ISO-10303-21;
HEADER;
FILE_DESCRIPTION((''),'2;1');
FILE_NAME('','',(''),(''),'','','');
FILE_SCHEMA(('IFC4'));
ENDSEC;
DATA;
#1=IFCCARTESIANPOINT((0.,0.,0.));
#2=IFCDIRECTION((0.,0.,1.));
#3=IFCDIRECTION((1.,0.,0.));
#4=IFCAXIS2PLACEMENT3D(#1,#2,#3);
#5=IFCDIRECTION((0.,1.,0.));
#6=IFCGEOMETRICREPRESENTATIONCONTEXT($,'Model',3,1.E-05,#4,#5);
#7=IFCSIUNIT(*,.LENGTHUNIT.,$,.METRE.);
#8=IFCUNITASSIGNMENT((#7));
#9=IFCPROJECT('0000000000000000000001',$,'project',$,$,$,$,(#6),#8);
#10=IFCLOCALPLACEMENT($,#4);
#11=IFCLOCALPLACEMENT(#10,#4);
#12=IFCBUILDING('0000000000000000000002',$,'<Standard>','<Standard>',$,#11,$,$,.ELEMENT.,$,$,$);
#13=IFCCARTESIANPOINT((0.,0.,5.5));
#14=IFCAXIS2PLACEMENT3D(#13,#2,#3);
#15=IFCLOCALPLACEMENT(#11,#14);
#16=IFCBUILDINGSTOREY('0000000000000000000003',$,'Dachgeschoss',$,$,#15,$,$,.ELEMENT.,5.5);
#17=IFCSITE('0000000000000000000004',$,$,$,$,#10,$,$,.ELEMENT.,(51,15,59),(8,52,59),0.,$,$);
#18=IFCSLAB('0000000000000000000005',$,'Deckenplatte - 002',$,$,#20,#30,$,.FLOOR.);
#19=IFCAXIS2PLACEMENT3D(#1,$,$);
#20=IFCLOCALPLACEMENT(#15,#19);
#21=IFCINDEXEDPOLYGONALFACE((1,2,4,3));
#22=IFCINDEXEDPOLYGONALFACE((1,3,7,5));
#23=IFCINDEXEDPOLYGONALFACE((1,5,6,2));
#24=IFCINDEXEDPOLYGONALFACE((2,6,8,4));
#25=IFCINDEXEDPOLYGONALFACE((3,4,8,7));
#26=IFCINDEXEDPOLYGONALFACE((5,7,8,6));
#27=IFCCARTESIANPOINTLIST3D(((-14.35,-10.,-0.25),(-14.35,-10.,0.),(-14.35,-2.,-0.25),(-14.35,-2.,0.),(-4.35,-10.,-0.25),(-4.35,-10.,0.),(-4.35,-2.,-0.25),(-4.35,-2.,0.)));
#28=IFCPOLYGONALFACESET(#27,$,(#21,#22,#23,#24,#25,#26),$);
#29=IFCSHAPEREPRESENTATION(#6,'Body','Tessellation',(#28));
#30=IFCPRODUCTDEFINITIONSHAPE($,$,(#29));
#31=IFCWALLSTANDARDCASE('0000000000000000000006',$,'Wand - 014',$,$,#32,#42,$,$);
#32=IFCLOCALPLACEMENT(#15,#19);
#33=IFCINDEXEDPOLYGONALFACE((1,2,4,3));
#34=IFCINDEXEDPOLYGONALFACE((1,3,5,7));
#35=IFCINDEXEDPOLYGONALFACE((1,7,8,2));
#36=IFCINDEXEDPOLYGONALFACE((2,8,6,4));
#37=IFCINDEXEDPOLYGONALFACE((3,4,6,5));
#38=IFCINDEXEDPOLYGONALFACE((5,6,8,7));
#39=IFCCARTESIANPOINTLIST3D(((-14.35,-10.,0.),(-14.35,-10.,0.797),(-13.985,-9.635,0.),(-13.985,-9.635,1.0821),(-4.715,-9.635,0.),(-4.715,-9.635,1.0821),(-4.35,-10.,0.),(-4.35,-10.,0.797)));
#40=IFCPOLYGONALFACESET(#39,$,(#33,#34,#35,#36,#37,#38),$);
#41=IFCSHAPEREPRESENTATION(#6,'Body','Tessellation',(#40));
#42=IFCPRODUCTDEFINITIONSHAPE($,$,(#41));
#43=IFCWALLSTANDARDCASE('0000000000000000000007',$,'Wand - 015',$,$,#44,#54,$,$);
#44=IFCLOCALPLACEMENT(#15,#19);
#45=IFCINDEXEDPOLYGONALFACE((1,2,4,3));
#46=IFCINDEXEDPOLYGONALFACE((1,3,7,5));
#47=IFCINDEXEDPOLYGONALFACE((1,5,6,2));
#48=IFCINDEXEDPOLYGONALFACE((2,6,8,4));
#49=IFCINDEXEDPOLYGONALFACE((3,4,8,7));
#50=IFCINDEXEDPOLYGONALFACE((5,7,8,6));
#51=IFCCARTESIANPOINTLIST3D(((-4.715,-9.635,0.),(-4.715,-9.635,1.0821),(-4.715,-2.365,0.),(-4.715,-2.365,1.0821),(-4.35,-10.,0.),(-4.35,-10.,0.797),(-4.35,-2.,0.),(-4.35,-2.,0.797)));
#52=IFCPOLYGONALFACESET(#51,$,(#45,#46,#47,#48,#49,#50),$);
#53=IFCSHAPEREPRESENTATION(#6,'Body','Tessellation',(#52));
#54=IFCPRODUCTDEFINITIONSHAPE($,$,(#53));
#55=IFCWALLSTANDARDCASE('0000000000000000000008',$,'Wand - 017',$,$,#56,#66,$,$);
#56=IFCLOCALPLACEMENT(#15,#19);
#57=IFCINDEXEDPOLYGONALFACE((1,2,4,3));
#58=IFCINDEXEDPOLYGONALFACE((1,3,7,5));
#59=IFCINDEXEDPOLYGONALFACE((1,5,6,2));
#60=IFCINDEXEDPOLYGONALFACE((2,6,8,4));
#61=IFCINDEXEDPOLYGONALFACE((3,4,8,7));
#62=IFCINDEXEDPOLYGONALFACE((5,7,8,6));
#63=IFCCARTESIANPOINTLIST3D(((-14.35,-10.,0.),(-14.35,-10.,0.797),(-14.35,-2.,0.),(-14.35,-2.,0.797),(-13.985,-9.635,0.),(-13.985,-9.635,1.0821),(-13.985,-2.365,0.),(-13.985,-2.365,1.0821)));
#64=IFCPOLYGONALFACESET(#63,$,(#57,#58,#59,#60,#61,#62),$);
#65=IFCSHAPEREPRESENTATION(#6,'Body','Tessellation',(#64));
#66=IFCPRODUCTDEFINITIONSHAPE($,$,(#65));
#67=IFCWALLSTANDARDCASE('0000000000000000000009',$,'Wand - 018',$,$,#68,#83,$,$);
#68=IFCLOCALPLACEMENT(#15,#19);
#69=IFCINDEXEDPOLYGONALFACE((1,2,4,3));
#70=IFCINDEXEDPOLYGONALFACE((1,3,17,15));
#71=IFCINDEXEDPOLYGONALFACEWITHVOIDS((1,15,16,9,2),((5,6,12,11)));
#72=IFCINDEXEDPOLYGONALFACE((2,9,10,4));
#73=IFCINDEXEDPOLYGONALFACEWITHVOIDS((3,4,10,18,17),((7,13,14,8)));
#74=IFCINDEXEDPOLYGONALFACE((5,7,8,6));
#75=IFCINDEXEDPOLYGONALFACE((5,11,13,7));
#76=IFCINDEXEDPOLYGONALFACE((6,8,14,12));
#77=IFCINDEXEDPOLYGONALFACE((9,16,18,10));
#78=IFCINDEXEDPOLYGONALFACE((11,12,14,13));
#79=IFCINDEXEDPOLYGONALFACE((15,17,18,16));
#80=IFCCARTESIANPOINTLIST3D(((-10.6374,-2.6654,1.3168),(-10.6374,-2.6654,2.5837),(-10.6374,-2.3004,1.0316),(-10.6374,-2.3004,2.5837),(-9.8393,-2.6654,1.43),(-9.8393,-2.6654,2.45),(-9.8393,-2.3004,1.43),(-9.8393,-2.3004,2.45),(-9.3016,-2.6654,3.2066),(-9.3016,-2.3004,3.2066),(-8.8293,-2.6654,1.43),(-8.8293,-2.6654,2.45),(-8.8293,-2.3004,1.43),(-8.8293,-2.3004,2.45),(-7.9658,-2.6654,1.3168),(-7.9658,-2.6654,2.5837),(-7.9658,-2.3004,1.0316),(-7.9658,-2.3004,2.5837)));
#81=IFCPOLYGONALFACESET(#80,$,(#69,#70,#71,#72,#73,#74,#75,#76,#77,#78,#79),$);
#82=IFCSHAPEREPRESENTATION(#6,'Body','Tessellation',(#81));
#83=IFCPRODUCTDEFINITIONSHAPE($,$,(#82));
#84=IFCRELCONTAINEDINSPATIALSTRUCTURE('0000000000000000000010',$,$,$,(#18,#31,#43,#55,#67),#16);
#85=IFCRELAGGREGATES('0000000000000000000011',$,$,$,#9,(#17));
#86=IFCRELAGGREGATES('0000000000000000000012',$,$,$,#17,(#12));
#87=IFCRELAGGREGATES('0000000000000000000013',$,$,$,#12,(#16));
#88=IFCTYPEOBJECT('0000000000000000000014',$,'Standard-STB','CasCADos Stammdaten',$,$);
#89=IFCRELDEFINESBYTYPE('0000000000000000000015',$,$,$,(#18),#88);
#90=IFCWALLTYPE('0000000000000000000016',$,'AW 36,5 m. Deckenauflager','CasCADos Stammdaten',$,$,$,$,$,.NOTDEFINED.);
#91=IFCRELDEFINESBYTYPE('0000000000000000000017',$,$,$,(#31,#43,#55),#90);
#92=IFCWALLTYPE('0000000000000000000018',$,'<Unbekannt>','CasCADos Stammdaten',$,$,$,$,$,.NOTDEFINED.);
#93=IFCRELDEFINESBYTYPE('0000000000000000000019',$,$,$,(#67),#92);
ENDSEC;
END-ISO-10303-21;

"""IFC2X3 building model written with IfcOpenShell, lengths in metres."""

from ifc_helpers import new_model, si_unit, direction, frame, origin_with_axes, place, context, project, spatial, polyline, outline, extrude, clip, bounded_halfspace, type_object, element, save


model = new_model("IFC2X3")

# Units and contexts
model_context = context("Model", 3, precision=1e-05, world=origin_with_axes(), true_north=direction((0.0, 1.0, 0.0)))
ifc_project = project(units=[si_unit("LENGTHUNIT", "METRE")], contexts=[model_context])

# Site, building, storey
site_placement = place(None, origin_with_axes())
site = spatial("IfcSite", under=ifc_project, at=site_placement, CompositionType="ELEMENT", RefLatitude=(51, 15, 59), RefLongitude=(8, 52, 59), RefElevation=0.0)
building_placement = place(site_placement, origin_with_axes())
building = spatial("IfcBuilding", under=site, at=building_placement, Name="<Standard>", Description="<Standard>", CompositionType="ELEMENT")
storey_placement = place(building_placement, frame((0.0, 0.0, 5.5), z_axis=(0.0, 0.0, 1.0), x_axis=(1.0, 0.0, 0.0)))
storey = spatial("IfcBuildingStorey", under=building, at=storey_placement, Name="Dachgeschoss", CompositionType="ELEMENT", Elevation=5.5)

# Slab
ifc_type_object_1 = type_object("IfcTypeObject", Name="Standard-STB", Description="CasCADos Stammdaten")
slab_1_placement = place(storey_placement, frame((-9.35, -6.0, -0.25), z_axis=(0.0, 0.0, 1.0), x_axis=(1.0, 0.0, 0.0)))
element("IfcSlab", 1, at=slab_1_placement, inside=storey, type_object=ifc_type_object_1, Name="Deckenplatte - 002", PredefinedType="FLOOR", context=model_context, shape_type="SweptSolid", body=[
    extrude(outline(polyline([(-5.0, -4.0), (5.0, -4.0), (5.0, 4.0), (-5.0, 4.0), (-5.0, -4.0)])), origin_with_axes(), (0.0, 0.0, 1.0), 0.25),
])

# Shared definitions
wall_type_1 = type_object("IfcWallType", Name="<Unbekannt>", Description="CasCADos Stammdaten", PredefinedType="NOTDEFINED")

# Walls
wall_type_2 = type_object("IfcWallType", Name="AW 36,5 m. Deckenauflager", Description="CasCADos Stammdaten", PredefinedType="NOTDEFINED")
wall_1_placement = place(storey_placement, frame((-14.35, -10.0, 0.0), z_axis=(0.0, 0.0, 1.0), x_axis=(1.0, 0.0, 0.0)))
element("IfcWallStandardCase", 2, at=wall_1_placement, inside=storey, type_object=wall_type_2, Name="Wand - 014", context=model_context, shape_type="Clipping", body=[
    clip(extrude(outline(polyline([(0.365, 0.365), (0.0, 0.0), (10.0, 0.0), (9.635, 0.365), (0.365, 0.365)])), origin_with_axes(), (0.0, 0.0, 1.0), 2.8), bounded_halfspace(frame((14.35, 3.1547, 3.2616), z_axis=(0.0, -0.615662, 0.788011), x_axis=(1.0, 0.0, 0.0)), False, origin_with_axes(), polyline([(0.0, 0.0), (4.2251, 0.0), (4.2451, 0.0), (10.0, 0.0), (9.635, 0.365), (0.365, 0.365), (0.0, 0.0)]))),
])
wall_2_placement = place(storey_placement, frame((-4.35, -10.0, 0.0), z_axis=(0.0, 0.0, 1.0), x_axis=(0.0, 1.0, 0.0)))
element("IfcWallStandardCase", 3, at=wall_2_placement, inside=storey, type_object=wall_type_2, Name="Wand - 015", context=model_context, shape_type="Clipping", body=[
    clip(extrude(outline(polyline([(0.365, 0.365), (0.0, 0.0), (8.0, 0.0), (7.635, 0.365), (0.365, 0.365)])), origin_with_axes(), (0.0, 0.0, 1.0), 2.8), bounded_halfspace(frame((10.0, -5.7561, -3.7002), z_axis=(0.0, -0.615662, 0.788011), x_axis=(1.0, 0.0, 0.0)), False, origin_with_axes(), polyline([(0.365, 0.365), (0.0, 0.0), (8.0, 0.0), (7.635, 0.365), (0.365, 0.365)]))),
])
wall_3_placement = place(storey_placement, frame((-14.35, -2.0, 0.0), z_axis=(0.0, 0.0, 1.0), x_axis=(0.0, -1.0, 0.0)))
element("IfcWallStandardCase", 4, at=wall_3_placement, inside=storey, type_object=wall_type_2, Name="Wand - 017", context=model_context, shape_type="Clipping", body=[
    clip(extrude(outline(polyline([(0.365, 0.365), (0.0, 0.0), (8.0, 0.0), (7.635, 0.365), (0.365, 0.365)])), origin_with_axes(), (0.0, 0.0, 1.0), 2.8), bounded_halfspace(frame((-2.0, 5.8558, 5.372), z_axis=(0.0, -0.615662, 0.788011), x_axis=(1.0, 0.0, 0.0)), False, origin_with_axes(), polyline([(0.365, 0.365), (0.0, 0.0), (8.0, 0.0), (7.635, 0.365), (0.365, 0.365)]))),
])

# Wall, opening
wall_4_placement = place(storey_placement, frame((-7.9658, -2.4829, 0.0), z_axis=(0.0, 0.0, 1.0), x_axis=(-1.0, 0.0, 0.0)))
wall_4 = element("IfcWallStandardCase", 5, at=wall_4_placement, inside=storey, type_object=wall_type_1, Name="Wand - 018", context=model_context, shape_type="Clipping", body=[
    clip(clip(clip(extrude(outline(polyline([(0.0, 0.1825), (0.0, -0.1825), (2.6715, -0.1825), (2.6715, 0.1825), (0.0, 0.1825)])), origin_with_axes(), (0.0, 0.0, 1.0), 7.8), bounded_halfspace(frame((-7.9658, -4.7797, -2.5601), z_axis=(0.0, -0.615662, 0.788011), x_axis=(1.0, 0.0, 0.0)), True, origin_with_axes(), polyline([(0.0, -0.1825), (2.6715, -0.1825), (2.6715, 0.1825), (0.0, 0.1825), (0.0, -0.1825)]))), bounded_halfspace(frame((-9.6393, -2.4829, -1.9112), z_axis=(-0.422618, 0.0, 0.906308), x_axis=(0.0, -1.0, 0.0)), False, origin_with_axes(), polyline([(0.0, -0.1825), (1.3358, -0.1825), (1.3358, 0.1825), (0.0, 0.1825), (0.0, -0.1825)]))), bounded_halfspace(frame((-2.9697, -2.4829, 5.2142), z_axis=(0.422618, 0.0, 0.906308), x_axis=(0.0, 1.0, 0.0)), False, origin_with_axes(), polyline([(1.3358, -0.1825), (2.6715, -0.1825), (2.6715, 0.1825), (1.3358, 0.1825), (1.3358, -0.1825)]))),
])
opening_placement = place(wall_4_placement, frame((1.3684, 0.0, 0.05), z_axis=(0.0, 0.0, 1.0), x_axis=(1.0, 0.0, 0.0)))
element("IfcOpeningElement", 6, at=opening_placement, cuts=wall_4, context=model_context, shape_type="SweptSolid", body=[
    extrude(outline(polyline([(1.38, 0.505), (1.38, -0.505), (2.4, -0.505), (2.4, 0.505), (1.38, 0.505)])), frame((0.0, -0.1825, 0.0), z_axis=(0.0, 1.0, 0.0), x_axis=(0.0, 0.0, 1.0)), (0.0, 0.0, 1.0), 0.365),
])

save(model, "model.ifc")
